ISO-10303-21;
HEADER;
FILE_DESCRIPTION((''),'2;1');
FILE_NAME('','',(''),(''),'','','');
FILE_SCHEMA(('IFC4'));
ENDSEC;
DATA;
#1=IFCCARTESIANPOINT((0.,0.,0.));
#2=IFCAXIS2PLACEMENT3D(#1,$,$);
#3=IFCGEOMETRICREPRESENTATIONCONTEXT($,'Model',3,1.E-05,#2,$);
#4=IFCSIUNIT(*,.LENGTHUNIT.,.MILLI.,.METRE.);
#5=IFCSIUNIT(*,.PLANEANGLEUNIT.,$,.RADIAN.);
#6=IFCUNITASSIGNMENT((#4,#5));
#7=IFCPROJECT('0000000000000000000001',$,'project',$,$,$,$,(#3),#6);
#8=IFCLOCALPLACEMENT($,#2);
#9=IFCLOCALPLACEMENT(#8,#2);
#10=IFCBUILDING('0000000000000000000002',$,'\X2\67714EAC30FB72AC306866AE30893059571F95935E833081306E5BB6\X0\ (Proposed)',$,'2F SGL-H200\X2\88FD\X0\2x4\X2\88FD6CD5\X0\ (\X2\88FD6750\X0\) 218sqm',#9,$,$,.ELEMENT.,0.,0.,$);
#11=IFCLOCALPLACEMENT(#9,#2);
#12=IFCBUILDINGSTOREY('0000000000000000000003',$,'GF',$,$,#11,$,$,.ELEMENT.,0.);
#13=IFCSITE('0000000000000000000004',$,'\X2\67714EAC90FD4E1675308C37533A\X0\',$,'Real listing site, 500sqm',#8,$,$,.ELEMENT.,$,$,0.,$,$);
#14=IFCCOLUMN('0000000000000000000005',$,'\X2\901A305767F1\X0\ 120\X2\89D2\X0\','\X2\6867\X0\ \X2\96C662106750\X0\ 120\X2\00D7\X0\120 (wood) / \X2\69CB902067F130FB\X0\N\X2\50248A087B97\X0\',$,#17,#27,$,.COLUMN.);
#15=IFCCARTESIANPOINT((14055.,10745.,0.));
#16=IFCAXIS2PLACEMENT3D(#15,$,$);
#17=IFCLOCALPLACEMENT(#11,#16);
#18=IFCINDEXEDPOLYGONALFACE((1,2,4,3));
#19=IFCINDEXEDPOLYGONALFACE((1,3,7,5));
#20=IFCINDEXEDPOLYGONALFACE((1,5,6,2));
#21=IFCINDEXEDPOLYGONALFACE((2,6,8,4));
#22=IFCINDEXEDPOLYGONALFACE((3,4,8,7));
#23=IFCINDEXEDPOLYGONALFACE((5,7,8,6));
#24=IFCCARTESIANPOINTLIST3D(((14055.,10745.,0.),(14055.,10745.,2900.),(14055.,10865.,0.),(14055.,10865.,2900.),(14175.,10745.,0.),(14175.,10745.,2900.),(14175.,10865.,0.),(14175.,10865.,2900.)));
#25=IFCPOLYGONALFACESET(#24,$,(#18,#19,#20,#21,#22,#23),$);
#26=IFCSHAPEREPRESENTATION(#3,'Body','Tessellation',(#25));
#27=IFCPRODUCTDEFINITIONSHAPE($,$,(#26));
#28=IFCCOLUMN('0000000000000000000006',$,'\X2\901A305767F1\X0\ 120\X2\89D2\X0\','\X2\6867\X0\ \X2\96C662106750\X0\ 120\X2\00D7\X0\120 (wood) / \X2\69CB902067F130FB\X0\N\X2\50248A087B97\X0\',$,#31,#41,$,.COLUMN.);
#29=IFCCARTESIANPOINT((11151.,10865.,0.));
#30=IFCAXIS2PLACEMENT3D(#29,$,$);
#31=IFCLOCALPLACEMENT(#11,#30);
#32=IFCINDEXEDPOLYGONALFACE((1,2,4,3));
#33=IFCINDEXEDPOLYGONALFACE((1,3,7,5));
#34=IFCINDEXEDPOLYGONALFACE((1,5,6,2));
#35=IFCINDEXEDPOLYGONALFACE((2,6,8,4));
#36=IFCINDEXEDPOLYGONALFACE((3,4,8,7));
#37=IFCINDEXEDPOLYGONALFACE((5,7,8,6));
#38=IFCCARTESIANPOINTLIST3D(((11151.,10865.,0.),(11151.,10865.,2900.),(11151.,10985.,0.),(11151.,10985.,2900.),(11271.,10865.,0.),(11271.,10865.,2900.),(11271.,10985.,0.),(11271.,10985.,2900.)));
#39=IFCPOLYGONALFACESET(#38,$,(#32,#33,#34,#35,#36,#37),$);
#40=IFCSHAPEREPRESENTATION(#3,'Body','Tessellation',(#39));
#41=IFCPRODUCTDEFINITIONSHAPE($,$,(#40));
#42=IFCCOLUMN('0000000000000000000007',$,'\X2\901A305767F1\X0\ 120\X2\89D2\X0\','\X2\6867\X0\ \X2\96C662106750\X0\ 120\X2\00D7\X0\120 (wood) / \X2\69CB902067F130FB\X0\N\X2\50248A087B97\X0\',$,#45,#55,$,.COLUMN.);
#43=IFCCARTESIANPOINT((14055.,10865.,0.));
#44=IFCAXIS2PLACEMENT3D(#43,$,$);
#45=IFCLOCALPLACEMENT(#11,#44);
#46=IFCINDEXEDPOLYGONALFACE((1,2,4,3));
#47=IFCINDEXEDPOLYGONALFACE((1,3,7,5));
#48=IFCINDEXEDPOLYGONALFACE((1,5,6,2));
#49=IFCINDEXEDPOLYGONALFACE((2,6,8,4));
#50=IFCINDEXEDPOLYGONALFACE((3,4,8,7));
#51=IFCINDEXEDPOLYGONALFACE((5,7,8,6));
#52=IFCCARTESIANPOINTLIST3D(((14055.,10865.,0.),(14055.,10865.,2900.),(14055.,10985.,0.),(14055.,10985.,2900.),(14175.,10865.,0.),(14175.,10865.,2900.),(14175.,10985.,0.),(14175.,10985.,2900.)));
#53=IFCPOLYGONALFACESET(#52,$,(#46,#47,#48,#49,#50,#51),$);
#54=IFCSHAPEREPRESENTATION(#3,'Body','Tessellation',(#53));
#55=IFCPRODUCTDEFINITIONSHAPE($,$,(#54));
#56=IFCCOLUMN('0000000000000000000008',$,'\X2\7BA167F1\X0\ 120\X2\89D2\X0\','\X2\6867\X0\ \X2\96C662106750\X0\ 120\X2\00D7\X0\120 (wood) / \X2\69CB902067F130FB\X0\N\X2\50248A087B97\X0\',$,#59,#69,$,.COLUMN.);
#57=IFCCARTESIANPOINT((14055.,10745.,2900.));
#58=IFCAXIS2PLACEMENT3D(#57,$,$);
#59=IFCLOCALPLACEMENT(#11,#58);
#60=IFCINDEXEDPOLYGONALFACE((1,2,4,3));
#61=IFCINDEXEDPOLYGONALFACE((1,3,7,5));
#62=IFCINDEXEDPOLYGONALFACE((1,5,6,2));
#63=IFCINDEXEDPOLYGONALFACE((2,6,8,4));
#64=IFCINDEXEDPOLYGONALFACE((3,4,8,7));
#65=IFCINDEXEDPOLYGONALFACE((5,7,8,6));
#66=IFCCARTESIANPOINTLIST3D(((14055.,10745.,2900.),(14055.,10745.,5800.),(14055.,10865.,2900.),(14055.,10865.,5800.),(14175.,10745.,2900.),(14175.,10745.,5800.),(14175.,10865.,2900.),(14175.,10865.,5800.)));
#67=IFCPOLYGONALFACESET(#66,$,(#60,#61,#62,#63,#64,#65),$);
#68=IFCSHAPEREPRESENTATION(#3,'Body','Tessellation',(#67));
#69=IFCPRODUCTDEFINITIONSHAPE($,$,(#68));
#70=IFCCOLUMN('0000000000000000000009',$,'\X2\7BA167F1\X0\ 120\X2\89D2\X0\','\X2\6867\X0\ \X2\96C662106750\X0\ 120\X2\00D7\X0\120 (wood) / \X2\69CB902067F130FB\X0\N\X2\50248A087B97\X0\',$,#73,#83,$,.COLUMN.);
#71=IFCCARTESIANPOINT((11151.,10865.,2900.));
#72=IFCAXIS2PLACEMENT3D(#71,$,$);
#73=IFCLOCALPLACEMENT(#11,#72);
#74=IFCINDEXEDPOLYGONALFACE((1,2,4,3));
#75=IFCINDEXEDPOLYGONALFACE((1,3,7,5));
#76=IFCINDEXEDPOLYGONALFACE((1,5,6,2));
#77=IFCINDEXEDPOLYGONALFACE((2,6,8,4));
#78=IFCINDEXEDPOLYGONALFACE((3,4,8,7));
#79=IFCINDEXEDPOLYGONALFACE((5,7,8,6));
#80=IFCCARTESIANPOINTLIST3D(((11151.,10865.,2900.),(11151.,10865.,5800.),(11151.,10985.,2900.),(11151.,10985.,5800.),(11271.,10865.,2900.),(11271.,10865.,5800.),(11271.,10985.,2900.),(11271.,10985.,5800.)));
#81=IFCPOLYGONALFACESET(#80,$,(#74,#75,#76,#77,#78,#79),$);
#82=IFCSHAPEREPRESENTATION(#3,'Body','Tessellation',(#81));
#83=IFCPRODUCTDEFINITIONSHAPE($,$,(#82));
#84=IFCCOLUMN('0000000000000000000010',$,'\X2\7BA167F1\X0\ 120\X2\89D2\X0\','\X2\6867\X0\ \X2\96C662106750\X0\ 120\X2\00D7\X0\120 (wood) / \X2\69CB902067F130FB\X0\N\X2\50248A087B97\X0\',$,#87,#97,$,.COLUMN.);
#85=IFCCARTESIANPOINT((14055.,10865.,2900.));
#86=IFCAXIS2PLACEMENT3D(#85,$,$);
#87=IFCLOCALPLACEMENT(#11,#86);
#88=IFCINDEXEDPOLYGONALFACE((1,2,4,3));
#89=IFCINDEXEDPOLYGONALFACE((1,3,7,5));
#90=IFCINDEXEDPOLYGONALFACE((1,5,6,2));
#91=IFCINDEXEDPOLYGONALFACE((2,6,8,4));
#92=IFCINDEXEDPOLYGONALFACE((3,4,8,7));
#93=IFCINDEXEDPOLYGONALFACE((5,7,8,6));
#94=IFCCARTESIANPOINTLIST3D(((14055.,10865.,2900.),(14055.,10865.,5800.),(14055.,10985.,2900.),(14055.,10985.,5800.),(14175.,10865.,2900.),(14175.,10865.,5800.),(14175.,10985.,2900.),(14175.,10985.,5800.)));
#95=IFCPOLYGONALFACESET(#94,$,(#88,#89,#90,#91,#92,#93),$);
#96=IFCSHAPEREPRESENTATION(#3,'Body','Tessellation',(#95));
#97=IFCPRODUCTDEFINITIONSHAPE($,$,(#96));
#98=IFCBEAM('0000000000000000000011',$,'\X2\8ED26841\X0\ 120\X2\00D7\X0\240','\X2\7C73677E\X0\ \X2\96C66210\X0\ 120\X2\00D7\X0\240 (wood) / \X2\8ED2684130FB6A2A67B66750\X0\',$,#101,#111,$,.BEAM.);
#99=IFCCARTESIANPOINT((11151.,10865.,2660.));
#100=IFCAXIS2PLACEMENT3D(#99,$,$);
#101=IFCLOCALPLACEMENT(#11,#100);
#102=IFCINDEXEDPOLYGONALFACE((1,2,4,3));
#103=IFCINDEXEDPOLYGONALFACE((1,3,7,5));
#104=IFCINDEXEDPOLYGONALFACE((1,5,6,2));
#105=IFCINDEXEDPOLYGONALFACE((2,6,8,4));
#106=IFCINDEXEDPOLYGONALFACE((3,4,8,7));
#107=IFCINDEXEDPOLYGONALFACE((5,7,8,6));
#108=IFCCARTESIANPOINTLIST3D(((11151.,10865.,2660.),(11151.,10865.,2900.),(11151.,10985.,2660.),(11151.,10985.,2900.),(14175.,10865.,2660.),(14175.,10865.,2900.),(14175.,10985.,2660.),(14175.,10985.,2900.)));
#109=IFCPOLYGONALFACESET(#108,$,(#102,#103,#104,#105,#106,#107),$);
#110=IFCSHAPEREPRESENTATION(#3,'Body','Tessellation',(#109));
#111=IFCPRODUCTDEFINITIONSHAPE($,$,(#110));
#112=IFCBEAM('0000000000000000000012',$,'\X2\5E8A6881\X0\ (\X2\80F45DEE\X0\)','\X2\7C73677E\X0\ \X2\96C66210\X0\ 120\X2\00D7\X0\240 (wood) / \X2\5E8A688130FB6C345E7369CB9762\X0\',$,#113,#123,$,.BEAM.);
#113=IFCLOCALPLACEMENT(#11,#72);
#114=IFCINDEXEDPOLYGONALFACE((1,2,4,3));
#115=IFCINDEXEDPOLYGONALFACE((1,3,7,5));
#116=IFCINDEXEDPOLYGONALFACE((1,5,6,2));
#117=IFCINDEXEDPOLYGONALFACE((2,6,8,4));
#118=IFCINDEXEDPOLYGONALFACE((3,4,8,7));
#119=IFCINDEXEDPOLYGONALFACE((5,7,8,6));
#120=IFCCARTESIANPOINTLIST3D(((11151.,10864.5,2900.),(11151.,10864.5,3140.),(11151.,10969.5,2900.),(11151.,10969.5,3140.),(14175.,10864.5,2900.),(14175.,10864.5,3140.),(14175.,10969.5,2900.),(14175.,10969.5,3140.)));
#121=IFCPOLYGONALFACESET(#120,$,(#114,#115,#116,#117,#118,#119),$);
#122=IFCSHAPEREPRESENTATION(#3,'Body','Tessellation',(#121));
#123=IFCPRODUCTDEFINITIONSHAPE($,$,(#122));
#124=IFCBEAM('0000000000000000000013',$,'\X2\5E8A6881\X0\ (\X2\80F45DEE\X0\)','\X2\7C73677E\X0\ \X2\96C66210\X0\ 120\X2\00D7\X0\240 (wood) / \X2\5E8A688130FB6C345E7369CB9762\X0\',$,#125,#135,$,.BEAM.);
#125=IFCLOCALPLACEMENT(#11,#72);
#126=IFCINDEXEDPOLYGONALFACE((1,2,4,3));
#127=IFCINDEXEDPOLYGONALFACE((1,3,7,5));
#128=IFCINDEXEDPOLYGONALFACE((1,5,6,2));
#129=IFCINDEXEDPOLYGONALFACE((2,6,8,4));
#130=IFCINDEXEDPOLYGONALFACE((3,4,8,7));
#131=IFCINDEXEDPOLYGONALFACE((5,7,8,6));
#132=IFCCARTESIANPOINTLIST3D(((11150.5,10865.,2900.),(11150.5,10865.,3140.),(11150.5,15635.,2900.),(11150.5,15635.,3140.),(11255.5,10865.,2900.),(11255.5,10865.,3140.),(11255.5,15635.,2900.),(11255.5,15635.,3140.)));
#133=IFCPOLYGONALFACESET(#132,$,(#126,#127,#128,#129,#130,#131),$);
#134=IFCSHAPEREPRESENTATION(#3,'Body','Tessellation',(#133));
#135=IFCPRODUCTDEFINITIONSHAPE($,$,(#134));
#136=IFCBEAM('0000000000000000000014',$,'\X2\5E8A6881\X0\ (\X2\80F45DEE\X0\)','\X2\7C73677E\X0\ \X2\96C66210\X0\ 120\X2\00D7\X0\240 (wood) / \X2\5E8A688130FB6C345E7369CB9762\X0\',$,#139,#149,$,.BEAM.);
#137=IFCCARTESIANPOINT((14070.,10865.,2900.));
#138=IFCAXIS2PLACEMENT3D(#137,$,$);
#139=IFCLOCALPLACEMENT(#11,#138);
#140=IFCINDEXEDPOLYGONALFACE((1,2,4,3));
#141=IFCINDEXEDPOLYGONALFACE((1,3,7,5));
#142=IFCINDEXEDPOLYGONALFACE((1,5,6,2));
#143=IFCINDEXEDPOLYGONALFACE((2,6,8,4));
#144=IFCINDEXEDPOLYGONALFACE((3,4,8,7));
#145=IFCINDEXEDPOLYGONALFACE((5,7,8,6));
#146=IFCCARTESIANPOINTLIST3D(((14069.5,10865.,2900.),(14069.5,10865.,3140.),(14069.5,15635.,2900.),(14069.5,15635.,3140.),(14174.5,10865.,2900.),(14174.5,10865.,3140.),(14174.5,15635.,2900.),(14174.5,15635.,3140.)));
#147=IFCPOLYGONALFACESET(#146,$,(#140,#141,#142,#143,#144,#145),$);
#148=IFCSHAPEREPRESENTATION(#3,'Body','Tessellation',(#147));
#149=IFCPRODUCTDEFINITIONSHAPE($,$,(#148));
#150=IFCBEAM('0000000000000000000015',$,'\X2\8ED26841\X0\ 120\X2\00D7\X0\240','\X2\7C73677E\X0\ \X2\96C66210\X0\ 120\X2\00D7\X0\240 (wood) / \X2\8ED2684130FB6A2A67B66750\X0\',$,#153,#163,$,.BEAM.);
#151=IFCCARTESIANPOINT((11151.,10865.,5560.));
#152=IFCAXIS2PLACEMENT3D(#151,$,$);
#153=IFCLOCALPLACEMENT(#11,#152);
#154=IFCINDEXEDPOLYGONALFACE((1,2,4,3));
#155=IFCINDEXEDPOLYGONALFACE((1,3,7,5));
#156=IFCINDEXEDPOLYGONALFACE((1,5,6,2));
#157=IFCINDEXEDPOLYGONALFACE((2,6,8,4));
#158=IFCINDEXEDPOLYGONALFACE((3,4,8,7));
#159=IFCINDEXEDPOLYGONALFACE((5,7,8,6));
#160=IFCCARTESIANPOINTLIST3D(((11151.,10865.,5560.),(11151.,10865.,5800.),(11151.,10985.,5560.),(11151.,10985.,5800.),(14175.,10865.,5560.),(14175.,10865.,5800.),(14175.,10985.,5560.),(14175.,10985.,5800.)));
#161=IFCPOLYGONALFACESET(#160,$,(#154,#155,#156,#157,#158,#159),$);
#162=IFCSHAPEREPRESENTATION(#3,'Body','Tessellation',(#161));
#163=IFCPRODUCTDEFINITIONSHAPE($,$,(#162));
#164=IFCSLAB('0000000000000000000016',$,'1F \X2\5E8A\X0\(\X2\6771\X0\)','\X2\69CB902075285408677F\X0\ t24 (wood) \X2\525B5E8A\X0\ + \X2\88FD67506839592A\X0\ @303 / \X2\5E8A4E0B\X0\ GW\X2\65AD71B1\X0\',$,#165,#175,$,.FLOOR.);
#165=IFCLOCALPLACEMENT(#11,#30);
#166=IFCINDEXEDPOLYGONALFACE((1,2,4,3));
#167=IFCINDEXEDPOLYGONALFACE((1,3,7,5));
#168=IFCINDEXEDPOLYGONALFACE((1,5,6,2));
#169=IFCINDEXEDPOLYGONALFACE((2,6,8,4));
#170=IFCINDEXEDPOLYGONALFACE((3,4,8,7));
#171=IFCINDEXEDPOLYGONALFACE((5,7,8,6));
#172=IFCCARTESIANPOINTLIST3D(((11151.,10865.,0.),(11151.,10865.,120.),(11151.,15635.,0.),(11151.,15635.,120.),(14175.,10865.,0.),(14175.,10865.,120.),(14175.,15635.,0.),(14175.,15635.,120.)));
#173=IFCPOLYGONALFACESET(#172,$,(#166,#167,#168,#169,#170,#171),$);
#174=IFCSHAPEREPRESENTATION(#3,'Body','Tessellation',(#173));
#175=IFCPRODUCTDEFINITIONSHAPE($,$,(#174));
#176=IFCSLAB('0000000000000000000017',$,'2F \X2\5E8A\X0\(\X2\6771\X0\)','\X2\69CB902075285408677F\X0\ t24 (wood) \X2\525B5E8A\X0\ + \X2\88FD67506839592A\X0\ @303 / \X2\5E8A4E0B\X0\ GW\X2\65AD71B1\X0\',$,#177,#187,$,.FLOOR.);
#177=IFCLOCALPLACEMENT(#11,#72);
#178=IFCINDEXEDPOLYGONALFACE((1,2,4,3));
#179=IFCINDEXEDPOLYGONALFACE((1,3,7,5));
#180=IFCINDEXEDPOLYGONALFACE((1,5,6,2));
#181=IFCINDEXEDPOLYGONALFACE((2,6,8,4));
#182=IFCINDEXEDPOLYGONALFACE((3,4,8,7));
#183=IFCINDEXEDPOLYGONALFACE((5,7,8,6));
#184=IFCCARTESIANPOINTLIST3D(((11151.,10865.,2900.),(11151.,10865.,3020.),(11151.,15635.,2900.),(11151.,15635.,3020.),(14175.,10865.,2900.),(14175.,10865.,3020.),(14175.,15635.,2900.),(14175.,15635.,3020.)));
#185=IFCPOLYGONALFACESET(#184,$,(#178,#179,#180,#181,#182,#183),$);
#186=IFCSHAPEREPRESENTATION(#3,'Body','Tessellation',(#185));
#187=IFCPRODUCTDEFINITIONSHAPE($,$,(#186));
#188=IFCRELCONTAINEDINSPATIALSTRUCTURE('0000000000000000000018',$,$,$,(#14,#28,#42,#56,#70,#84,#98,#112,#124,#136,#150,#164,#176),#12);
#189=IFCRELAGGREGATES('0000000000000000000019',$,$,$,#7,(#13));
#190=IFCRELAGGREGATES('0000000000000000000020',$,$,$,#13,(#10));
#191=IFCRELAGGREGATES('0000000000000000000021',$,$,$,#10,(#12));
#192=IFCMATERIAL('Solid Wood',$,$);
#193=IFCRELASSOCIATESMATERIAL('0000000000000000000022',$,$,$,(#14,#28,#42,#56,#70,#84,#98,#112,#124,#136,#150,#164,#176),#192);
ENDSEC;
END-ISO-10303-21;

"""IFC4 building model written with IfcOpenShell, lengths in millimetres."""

from ifc_helpers import new_model, si_unit, frame, frame_2d, origin, place, context, project, spatial, rectangle, extrude, material, element, save


model = new_model("IFC4")

# Units and contexts
model_context = context("Model", 3, precision=1e-05, world=origin())
ifc_project = project(units=[si_unit("LENGTHUNIT", "METRE", prefix="MILLI"), si_unit("PLANEANGLEUNIT", "RADIAN")], contexts=[model_context])

# Site, building, storey
site_placement = place(None, origin())
site = spatial("IfcSite", under=ifc_project, at=site_placement, Name="東京都世田谷区", ObjectType="Real listing site, 500sqm", CompositionType="ELEMENT", RefElevation=0.0)
building_placement = place(site_placement, origin())
building = spatial("IfcBuilding", under=site, at=building_placement, Name="東京・犬と暮らす土間広めの家 (Proposed)", ObjectType="2F SGL-H200製2x4製法 (製材) 218sqm", CompositionType="ELEMENT", ElevationOfRefHeight=0.0, ElevationOfTerrain=0.0)
storey_placement = place(building_placement, origin())
storey = spatial("IfcBuildingStorey", under=building, at=storey_placement, Name="GF", CompositionType="ELEMENT", Elevation=0.0)

# Columns
ifc_material_1 = material(Name="Solid Wood")
column_1_placement = place(storey_placement, frame((14055.0, 10745.0, 0.0)))
element("IfcColumn", 1, at=column_1_placement, inside=storey, material=ifc_material_1, Name="通し柱 120角", Description="桧 集成材 120×120 (wood) / 構造柱・N値計算", PredefinedType="COLUMN", context=model_context, shape_type="SweptSolid", body=[
    extrude(rectangle(XDim=120.0, YDim=120.0, at=frame_2d((60.0, 60.0))), frame((14055.0, 10745.0, 0.0)), (0.0, 0.0, 1.0), 2900.0),
])
column_2_placement = place(storey_placement, frame((11151.0, 10865.0, 0.0)))
element("IfcColumn", 2, at=column_2_placement, inside=storey, material=ifc_material_1, Name="通し柱 120角", Description="桧 集成材 120×120 (wood) / 構造柱・N値計算", PredefinedType="COLUMN", context=model_context, shape_type="SweptSolid", body=[
    extrude(rectangle(XDim=120.0, YDim=120.0, at=frame_2d((60.0, 60.0))), frame((11151.0, 10865.0, 0.0)), (0.0, 0.0, 1.0), 2900.0),
])
column_3_placement = place(storey_placement, frame((14055.0, 10865.0, 0.0)))
element("IfcColumn", 3, at=column_3_placement, inside=storey, material=ifc_material_1, Name="通し柱 120角", Description="桧 集成材 120×120 (wood) / 構造柱・N値計算", PredefinedType="COLUMN", context=model_context, shape_type="SweptSolid", body=[
    extrude(rectangle(XDim=120.0, YDim=120.0, at=frame_2d((60.0, 60.0))), frame((14055.0, 10865.0, 0.0)), (0.0, 0.0, 1.0), 2900.0),
])
column_4_placement = place(storey_placement, frame((14055.0, 10745.0, 2900.0)))
element("IfcColumn", 4, at=column_4_placement, inside=storey, material=ifc_material_1, Name="管柱 120角", Description="桧 集成材 120×120 (wood) / 構造柱・N値計算", PredefinedType="COLUMN", context=model_context, shape_type="SweptSolid", body=[
    extrude(rectangle(XDim=120.0, YDim=120.0, at=frame_2d((60.0, 60.0))), frame((14055.0, 10745.0, 2900.0)), (0.0, 0.0, 1.0), 2900.0),
])
column_5_placement = place(storey_placement, frame((11151.0, 10865.0, 2900.0)))
element("IfcColumn", 5, at=column_5_placement, inside=storey, material=ifc_material_1, Name="管柱 120角", Description="桧 集成材 120×120 (wood) / 構造柱・N値計算", PredefinedType="COLUMN", context=model_context, shape_type="SweptSolid", body=[
    extrude(rectangle(XDim=120.0, YDim=120.0, at=frame_2d((60.0, 60.0))), frame((11151.0, 10865.0, 2900.0)), (0.0, 0.0, 1.0), 2900.0),
])
column_6_placement = place(storey_placement, frame((14055.0, 10865.0, 2900.0)))
element("IfcColumn", 6, at=column_6_placement, inside=storey, material=ifc_material_1, Name="管柱 120角", Description="桧 集成材 120×120 (wood) / 構造柱・N値計算", PredefinedType="COLUMN", context=model_context, shape_type="SweptSolid", body=[
    extrude(rectangle(XDim=120.0, YDim=120.0, at=frame_2d((60.0, 60.0))), frame((14055.0, 10865.0, 2900.0)), (0.0, 0.0, 1.0), 2900.0),
])

# Beams
beam_1_placement = place(storey_placement, frame((11151.0, 10865.0, 2660.0)))
element("IfcBeam", 7, at=beam_1_placement, inside=storey, material=ifc_material_1, Name="軒桁 120×240", Description="米松 集成 120×240 (wood) / 軒桁・横架材", PredefinedType="BEAM", context=model_context, shape_type="SweptSolid", body=[
    extrude(rectangle(XDim=3024.0, YDim=120.0, at=frame_2d((1512.0, 60.0))), frame((11151.0, 10865.0, 2660.0)), (0.0, 0.0, 1.0), 240.0),
])
beam_2_placement = place(storey_placement, frame((11151.0, 10865.0, 2900.0)))
element("IfcBeam", 8, at=beam_2_placement, inside=storey, material=ifc_material_1, Name="床梁 (胴差)", Description="米松 集成 120×240 (wood) / 床梁・水平構面", PredefinedType="BEAM", context=model_context, shape_type="SweptSolid", body=[
    extrude(rectangle(XDim=3024.0, YDim=105.0, at=frame_2d((1512.0, 52.0))), frame((11151.0, 10865.0, 2900.0)), (0.0, 0.0, 1.0), 240.0),
])
beam_3_placement = place(storey_placement, frame((11151.0, 10865.0, 2900.0)))
element("IfcBeam", 9, at=beam_3_placement, inside=storey, material=ifc_material_1, Name="床梁 (胴差)", Description="米松 集成 120×240 (wood) / 床梁・水平構面", PredefinedType="BEAM", context=model_context, shape_type="SweptSolid", body=[
    extrude(rectangle(XDim=105.0, YDim=4770.0, at=frame_2d((52.0, 2385.0))), frame((11151.0, 10865.0, 2900.0)), (0.0, 0.0, 1.0), 240.0),
])
beam_4_placement = place(storey_placement, frame((14070.0, 10865.0, 2900.0)))
element("IfcBeam", 10, at=beam_4_placement, inside=storey, material=ifc_material_1, Name="床梁 (胴差)", Description="米松 集成 120×240 (wood) / 床梁・水平構面", PredefinedType="BEAM", context=model_context, shape_type="SweptSolid", body=[
    extrude(rectangle(XDim=105.0, YDim=4770.0, at=frame_2d((52.0, 2385.0))), frame((14070.0, 10865.0, 2900.0)), (0.0, 0.0, 1.0), 240.0),
])
beam_5_placement = place(storey_placement, frame((11151.0, 10865.0, 5560.0)))
element("IfcBeam", 11, at=beam_5_placement, inside=storey, material=ifc_material_1, Name="軒桁 120×240", Description="米松 集成 120×240 (wood) / 軒桁・横架材", PredefinedType="BEAM", context=model_context, shape_type="SweptSolid", body=[
    extrude(rectangle(XDim=3024.0, YDim=120.0, at=frame_2d((1512.0, 60.0))), frame((11151.0, 10865.0, 5560.0)), (0.0, 0.0, 1.0), 240.0),
])

# Slabs
slab_1_placement = place(storey_placement, frame((11151.0, 10865.0, 0.0)))
element("IfcSlab", 12, at=slab_1_placement, inside=storey, material=ifc_material_1, Name="1F 床(東)", Description="構造用合板 t24 (wood) 剛床 + 製材根太 @303 / 床下 GW断熱", PredefinedType="FLOOR", context=model_context, shape_type="SweptSolid", body=[
    extrude(rectangle(XDim=3024.0, YDim=4770.0, at=frame_2d((1512.0, 2385.0))), frame((11151.0, 10865.0, 0.0)), (0.0, 0.0, 1.0), 120.0),
])
slab_2_placement = place(storey_placement, frame((11151.0, 10865.0, 2900.0)))
element("IfcSlab", 13, at=slab_2_placement, inside=storey, material=ifc_material_1, Name="2F 床(東)", Description="構造用合板 t24 (wood) 剛床 + 製材根太 @303 / 床下 GW断熱", PredefinedType="FLOOR", context=model_context, shape_type="SweptSolid", body=[
    extrude(rectangle(XDim=3024.0, YDim=4770.0, at=frame_2d((1512.0, 2385.0))), frame((11151.0, 10865.0, 2900.0)), (0.0, 0.0, 1.0), 120.0),
])

save(model, "model.ifc")
